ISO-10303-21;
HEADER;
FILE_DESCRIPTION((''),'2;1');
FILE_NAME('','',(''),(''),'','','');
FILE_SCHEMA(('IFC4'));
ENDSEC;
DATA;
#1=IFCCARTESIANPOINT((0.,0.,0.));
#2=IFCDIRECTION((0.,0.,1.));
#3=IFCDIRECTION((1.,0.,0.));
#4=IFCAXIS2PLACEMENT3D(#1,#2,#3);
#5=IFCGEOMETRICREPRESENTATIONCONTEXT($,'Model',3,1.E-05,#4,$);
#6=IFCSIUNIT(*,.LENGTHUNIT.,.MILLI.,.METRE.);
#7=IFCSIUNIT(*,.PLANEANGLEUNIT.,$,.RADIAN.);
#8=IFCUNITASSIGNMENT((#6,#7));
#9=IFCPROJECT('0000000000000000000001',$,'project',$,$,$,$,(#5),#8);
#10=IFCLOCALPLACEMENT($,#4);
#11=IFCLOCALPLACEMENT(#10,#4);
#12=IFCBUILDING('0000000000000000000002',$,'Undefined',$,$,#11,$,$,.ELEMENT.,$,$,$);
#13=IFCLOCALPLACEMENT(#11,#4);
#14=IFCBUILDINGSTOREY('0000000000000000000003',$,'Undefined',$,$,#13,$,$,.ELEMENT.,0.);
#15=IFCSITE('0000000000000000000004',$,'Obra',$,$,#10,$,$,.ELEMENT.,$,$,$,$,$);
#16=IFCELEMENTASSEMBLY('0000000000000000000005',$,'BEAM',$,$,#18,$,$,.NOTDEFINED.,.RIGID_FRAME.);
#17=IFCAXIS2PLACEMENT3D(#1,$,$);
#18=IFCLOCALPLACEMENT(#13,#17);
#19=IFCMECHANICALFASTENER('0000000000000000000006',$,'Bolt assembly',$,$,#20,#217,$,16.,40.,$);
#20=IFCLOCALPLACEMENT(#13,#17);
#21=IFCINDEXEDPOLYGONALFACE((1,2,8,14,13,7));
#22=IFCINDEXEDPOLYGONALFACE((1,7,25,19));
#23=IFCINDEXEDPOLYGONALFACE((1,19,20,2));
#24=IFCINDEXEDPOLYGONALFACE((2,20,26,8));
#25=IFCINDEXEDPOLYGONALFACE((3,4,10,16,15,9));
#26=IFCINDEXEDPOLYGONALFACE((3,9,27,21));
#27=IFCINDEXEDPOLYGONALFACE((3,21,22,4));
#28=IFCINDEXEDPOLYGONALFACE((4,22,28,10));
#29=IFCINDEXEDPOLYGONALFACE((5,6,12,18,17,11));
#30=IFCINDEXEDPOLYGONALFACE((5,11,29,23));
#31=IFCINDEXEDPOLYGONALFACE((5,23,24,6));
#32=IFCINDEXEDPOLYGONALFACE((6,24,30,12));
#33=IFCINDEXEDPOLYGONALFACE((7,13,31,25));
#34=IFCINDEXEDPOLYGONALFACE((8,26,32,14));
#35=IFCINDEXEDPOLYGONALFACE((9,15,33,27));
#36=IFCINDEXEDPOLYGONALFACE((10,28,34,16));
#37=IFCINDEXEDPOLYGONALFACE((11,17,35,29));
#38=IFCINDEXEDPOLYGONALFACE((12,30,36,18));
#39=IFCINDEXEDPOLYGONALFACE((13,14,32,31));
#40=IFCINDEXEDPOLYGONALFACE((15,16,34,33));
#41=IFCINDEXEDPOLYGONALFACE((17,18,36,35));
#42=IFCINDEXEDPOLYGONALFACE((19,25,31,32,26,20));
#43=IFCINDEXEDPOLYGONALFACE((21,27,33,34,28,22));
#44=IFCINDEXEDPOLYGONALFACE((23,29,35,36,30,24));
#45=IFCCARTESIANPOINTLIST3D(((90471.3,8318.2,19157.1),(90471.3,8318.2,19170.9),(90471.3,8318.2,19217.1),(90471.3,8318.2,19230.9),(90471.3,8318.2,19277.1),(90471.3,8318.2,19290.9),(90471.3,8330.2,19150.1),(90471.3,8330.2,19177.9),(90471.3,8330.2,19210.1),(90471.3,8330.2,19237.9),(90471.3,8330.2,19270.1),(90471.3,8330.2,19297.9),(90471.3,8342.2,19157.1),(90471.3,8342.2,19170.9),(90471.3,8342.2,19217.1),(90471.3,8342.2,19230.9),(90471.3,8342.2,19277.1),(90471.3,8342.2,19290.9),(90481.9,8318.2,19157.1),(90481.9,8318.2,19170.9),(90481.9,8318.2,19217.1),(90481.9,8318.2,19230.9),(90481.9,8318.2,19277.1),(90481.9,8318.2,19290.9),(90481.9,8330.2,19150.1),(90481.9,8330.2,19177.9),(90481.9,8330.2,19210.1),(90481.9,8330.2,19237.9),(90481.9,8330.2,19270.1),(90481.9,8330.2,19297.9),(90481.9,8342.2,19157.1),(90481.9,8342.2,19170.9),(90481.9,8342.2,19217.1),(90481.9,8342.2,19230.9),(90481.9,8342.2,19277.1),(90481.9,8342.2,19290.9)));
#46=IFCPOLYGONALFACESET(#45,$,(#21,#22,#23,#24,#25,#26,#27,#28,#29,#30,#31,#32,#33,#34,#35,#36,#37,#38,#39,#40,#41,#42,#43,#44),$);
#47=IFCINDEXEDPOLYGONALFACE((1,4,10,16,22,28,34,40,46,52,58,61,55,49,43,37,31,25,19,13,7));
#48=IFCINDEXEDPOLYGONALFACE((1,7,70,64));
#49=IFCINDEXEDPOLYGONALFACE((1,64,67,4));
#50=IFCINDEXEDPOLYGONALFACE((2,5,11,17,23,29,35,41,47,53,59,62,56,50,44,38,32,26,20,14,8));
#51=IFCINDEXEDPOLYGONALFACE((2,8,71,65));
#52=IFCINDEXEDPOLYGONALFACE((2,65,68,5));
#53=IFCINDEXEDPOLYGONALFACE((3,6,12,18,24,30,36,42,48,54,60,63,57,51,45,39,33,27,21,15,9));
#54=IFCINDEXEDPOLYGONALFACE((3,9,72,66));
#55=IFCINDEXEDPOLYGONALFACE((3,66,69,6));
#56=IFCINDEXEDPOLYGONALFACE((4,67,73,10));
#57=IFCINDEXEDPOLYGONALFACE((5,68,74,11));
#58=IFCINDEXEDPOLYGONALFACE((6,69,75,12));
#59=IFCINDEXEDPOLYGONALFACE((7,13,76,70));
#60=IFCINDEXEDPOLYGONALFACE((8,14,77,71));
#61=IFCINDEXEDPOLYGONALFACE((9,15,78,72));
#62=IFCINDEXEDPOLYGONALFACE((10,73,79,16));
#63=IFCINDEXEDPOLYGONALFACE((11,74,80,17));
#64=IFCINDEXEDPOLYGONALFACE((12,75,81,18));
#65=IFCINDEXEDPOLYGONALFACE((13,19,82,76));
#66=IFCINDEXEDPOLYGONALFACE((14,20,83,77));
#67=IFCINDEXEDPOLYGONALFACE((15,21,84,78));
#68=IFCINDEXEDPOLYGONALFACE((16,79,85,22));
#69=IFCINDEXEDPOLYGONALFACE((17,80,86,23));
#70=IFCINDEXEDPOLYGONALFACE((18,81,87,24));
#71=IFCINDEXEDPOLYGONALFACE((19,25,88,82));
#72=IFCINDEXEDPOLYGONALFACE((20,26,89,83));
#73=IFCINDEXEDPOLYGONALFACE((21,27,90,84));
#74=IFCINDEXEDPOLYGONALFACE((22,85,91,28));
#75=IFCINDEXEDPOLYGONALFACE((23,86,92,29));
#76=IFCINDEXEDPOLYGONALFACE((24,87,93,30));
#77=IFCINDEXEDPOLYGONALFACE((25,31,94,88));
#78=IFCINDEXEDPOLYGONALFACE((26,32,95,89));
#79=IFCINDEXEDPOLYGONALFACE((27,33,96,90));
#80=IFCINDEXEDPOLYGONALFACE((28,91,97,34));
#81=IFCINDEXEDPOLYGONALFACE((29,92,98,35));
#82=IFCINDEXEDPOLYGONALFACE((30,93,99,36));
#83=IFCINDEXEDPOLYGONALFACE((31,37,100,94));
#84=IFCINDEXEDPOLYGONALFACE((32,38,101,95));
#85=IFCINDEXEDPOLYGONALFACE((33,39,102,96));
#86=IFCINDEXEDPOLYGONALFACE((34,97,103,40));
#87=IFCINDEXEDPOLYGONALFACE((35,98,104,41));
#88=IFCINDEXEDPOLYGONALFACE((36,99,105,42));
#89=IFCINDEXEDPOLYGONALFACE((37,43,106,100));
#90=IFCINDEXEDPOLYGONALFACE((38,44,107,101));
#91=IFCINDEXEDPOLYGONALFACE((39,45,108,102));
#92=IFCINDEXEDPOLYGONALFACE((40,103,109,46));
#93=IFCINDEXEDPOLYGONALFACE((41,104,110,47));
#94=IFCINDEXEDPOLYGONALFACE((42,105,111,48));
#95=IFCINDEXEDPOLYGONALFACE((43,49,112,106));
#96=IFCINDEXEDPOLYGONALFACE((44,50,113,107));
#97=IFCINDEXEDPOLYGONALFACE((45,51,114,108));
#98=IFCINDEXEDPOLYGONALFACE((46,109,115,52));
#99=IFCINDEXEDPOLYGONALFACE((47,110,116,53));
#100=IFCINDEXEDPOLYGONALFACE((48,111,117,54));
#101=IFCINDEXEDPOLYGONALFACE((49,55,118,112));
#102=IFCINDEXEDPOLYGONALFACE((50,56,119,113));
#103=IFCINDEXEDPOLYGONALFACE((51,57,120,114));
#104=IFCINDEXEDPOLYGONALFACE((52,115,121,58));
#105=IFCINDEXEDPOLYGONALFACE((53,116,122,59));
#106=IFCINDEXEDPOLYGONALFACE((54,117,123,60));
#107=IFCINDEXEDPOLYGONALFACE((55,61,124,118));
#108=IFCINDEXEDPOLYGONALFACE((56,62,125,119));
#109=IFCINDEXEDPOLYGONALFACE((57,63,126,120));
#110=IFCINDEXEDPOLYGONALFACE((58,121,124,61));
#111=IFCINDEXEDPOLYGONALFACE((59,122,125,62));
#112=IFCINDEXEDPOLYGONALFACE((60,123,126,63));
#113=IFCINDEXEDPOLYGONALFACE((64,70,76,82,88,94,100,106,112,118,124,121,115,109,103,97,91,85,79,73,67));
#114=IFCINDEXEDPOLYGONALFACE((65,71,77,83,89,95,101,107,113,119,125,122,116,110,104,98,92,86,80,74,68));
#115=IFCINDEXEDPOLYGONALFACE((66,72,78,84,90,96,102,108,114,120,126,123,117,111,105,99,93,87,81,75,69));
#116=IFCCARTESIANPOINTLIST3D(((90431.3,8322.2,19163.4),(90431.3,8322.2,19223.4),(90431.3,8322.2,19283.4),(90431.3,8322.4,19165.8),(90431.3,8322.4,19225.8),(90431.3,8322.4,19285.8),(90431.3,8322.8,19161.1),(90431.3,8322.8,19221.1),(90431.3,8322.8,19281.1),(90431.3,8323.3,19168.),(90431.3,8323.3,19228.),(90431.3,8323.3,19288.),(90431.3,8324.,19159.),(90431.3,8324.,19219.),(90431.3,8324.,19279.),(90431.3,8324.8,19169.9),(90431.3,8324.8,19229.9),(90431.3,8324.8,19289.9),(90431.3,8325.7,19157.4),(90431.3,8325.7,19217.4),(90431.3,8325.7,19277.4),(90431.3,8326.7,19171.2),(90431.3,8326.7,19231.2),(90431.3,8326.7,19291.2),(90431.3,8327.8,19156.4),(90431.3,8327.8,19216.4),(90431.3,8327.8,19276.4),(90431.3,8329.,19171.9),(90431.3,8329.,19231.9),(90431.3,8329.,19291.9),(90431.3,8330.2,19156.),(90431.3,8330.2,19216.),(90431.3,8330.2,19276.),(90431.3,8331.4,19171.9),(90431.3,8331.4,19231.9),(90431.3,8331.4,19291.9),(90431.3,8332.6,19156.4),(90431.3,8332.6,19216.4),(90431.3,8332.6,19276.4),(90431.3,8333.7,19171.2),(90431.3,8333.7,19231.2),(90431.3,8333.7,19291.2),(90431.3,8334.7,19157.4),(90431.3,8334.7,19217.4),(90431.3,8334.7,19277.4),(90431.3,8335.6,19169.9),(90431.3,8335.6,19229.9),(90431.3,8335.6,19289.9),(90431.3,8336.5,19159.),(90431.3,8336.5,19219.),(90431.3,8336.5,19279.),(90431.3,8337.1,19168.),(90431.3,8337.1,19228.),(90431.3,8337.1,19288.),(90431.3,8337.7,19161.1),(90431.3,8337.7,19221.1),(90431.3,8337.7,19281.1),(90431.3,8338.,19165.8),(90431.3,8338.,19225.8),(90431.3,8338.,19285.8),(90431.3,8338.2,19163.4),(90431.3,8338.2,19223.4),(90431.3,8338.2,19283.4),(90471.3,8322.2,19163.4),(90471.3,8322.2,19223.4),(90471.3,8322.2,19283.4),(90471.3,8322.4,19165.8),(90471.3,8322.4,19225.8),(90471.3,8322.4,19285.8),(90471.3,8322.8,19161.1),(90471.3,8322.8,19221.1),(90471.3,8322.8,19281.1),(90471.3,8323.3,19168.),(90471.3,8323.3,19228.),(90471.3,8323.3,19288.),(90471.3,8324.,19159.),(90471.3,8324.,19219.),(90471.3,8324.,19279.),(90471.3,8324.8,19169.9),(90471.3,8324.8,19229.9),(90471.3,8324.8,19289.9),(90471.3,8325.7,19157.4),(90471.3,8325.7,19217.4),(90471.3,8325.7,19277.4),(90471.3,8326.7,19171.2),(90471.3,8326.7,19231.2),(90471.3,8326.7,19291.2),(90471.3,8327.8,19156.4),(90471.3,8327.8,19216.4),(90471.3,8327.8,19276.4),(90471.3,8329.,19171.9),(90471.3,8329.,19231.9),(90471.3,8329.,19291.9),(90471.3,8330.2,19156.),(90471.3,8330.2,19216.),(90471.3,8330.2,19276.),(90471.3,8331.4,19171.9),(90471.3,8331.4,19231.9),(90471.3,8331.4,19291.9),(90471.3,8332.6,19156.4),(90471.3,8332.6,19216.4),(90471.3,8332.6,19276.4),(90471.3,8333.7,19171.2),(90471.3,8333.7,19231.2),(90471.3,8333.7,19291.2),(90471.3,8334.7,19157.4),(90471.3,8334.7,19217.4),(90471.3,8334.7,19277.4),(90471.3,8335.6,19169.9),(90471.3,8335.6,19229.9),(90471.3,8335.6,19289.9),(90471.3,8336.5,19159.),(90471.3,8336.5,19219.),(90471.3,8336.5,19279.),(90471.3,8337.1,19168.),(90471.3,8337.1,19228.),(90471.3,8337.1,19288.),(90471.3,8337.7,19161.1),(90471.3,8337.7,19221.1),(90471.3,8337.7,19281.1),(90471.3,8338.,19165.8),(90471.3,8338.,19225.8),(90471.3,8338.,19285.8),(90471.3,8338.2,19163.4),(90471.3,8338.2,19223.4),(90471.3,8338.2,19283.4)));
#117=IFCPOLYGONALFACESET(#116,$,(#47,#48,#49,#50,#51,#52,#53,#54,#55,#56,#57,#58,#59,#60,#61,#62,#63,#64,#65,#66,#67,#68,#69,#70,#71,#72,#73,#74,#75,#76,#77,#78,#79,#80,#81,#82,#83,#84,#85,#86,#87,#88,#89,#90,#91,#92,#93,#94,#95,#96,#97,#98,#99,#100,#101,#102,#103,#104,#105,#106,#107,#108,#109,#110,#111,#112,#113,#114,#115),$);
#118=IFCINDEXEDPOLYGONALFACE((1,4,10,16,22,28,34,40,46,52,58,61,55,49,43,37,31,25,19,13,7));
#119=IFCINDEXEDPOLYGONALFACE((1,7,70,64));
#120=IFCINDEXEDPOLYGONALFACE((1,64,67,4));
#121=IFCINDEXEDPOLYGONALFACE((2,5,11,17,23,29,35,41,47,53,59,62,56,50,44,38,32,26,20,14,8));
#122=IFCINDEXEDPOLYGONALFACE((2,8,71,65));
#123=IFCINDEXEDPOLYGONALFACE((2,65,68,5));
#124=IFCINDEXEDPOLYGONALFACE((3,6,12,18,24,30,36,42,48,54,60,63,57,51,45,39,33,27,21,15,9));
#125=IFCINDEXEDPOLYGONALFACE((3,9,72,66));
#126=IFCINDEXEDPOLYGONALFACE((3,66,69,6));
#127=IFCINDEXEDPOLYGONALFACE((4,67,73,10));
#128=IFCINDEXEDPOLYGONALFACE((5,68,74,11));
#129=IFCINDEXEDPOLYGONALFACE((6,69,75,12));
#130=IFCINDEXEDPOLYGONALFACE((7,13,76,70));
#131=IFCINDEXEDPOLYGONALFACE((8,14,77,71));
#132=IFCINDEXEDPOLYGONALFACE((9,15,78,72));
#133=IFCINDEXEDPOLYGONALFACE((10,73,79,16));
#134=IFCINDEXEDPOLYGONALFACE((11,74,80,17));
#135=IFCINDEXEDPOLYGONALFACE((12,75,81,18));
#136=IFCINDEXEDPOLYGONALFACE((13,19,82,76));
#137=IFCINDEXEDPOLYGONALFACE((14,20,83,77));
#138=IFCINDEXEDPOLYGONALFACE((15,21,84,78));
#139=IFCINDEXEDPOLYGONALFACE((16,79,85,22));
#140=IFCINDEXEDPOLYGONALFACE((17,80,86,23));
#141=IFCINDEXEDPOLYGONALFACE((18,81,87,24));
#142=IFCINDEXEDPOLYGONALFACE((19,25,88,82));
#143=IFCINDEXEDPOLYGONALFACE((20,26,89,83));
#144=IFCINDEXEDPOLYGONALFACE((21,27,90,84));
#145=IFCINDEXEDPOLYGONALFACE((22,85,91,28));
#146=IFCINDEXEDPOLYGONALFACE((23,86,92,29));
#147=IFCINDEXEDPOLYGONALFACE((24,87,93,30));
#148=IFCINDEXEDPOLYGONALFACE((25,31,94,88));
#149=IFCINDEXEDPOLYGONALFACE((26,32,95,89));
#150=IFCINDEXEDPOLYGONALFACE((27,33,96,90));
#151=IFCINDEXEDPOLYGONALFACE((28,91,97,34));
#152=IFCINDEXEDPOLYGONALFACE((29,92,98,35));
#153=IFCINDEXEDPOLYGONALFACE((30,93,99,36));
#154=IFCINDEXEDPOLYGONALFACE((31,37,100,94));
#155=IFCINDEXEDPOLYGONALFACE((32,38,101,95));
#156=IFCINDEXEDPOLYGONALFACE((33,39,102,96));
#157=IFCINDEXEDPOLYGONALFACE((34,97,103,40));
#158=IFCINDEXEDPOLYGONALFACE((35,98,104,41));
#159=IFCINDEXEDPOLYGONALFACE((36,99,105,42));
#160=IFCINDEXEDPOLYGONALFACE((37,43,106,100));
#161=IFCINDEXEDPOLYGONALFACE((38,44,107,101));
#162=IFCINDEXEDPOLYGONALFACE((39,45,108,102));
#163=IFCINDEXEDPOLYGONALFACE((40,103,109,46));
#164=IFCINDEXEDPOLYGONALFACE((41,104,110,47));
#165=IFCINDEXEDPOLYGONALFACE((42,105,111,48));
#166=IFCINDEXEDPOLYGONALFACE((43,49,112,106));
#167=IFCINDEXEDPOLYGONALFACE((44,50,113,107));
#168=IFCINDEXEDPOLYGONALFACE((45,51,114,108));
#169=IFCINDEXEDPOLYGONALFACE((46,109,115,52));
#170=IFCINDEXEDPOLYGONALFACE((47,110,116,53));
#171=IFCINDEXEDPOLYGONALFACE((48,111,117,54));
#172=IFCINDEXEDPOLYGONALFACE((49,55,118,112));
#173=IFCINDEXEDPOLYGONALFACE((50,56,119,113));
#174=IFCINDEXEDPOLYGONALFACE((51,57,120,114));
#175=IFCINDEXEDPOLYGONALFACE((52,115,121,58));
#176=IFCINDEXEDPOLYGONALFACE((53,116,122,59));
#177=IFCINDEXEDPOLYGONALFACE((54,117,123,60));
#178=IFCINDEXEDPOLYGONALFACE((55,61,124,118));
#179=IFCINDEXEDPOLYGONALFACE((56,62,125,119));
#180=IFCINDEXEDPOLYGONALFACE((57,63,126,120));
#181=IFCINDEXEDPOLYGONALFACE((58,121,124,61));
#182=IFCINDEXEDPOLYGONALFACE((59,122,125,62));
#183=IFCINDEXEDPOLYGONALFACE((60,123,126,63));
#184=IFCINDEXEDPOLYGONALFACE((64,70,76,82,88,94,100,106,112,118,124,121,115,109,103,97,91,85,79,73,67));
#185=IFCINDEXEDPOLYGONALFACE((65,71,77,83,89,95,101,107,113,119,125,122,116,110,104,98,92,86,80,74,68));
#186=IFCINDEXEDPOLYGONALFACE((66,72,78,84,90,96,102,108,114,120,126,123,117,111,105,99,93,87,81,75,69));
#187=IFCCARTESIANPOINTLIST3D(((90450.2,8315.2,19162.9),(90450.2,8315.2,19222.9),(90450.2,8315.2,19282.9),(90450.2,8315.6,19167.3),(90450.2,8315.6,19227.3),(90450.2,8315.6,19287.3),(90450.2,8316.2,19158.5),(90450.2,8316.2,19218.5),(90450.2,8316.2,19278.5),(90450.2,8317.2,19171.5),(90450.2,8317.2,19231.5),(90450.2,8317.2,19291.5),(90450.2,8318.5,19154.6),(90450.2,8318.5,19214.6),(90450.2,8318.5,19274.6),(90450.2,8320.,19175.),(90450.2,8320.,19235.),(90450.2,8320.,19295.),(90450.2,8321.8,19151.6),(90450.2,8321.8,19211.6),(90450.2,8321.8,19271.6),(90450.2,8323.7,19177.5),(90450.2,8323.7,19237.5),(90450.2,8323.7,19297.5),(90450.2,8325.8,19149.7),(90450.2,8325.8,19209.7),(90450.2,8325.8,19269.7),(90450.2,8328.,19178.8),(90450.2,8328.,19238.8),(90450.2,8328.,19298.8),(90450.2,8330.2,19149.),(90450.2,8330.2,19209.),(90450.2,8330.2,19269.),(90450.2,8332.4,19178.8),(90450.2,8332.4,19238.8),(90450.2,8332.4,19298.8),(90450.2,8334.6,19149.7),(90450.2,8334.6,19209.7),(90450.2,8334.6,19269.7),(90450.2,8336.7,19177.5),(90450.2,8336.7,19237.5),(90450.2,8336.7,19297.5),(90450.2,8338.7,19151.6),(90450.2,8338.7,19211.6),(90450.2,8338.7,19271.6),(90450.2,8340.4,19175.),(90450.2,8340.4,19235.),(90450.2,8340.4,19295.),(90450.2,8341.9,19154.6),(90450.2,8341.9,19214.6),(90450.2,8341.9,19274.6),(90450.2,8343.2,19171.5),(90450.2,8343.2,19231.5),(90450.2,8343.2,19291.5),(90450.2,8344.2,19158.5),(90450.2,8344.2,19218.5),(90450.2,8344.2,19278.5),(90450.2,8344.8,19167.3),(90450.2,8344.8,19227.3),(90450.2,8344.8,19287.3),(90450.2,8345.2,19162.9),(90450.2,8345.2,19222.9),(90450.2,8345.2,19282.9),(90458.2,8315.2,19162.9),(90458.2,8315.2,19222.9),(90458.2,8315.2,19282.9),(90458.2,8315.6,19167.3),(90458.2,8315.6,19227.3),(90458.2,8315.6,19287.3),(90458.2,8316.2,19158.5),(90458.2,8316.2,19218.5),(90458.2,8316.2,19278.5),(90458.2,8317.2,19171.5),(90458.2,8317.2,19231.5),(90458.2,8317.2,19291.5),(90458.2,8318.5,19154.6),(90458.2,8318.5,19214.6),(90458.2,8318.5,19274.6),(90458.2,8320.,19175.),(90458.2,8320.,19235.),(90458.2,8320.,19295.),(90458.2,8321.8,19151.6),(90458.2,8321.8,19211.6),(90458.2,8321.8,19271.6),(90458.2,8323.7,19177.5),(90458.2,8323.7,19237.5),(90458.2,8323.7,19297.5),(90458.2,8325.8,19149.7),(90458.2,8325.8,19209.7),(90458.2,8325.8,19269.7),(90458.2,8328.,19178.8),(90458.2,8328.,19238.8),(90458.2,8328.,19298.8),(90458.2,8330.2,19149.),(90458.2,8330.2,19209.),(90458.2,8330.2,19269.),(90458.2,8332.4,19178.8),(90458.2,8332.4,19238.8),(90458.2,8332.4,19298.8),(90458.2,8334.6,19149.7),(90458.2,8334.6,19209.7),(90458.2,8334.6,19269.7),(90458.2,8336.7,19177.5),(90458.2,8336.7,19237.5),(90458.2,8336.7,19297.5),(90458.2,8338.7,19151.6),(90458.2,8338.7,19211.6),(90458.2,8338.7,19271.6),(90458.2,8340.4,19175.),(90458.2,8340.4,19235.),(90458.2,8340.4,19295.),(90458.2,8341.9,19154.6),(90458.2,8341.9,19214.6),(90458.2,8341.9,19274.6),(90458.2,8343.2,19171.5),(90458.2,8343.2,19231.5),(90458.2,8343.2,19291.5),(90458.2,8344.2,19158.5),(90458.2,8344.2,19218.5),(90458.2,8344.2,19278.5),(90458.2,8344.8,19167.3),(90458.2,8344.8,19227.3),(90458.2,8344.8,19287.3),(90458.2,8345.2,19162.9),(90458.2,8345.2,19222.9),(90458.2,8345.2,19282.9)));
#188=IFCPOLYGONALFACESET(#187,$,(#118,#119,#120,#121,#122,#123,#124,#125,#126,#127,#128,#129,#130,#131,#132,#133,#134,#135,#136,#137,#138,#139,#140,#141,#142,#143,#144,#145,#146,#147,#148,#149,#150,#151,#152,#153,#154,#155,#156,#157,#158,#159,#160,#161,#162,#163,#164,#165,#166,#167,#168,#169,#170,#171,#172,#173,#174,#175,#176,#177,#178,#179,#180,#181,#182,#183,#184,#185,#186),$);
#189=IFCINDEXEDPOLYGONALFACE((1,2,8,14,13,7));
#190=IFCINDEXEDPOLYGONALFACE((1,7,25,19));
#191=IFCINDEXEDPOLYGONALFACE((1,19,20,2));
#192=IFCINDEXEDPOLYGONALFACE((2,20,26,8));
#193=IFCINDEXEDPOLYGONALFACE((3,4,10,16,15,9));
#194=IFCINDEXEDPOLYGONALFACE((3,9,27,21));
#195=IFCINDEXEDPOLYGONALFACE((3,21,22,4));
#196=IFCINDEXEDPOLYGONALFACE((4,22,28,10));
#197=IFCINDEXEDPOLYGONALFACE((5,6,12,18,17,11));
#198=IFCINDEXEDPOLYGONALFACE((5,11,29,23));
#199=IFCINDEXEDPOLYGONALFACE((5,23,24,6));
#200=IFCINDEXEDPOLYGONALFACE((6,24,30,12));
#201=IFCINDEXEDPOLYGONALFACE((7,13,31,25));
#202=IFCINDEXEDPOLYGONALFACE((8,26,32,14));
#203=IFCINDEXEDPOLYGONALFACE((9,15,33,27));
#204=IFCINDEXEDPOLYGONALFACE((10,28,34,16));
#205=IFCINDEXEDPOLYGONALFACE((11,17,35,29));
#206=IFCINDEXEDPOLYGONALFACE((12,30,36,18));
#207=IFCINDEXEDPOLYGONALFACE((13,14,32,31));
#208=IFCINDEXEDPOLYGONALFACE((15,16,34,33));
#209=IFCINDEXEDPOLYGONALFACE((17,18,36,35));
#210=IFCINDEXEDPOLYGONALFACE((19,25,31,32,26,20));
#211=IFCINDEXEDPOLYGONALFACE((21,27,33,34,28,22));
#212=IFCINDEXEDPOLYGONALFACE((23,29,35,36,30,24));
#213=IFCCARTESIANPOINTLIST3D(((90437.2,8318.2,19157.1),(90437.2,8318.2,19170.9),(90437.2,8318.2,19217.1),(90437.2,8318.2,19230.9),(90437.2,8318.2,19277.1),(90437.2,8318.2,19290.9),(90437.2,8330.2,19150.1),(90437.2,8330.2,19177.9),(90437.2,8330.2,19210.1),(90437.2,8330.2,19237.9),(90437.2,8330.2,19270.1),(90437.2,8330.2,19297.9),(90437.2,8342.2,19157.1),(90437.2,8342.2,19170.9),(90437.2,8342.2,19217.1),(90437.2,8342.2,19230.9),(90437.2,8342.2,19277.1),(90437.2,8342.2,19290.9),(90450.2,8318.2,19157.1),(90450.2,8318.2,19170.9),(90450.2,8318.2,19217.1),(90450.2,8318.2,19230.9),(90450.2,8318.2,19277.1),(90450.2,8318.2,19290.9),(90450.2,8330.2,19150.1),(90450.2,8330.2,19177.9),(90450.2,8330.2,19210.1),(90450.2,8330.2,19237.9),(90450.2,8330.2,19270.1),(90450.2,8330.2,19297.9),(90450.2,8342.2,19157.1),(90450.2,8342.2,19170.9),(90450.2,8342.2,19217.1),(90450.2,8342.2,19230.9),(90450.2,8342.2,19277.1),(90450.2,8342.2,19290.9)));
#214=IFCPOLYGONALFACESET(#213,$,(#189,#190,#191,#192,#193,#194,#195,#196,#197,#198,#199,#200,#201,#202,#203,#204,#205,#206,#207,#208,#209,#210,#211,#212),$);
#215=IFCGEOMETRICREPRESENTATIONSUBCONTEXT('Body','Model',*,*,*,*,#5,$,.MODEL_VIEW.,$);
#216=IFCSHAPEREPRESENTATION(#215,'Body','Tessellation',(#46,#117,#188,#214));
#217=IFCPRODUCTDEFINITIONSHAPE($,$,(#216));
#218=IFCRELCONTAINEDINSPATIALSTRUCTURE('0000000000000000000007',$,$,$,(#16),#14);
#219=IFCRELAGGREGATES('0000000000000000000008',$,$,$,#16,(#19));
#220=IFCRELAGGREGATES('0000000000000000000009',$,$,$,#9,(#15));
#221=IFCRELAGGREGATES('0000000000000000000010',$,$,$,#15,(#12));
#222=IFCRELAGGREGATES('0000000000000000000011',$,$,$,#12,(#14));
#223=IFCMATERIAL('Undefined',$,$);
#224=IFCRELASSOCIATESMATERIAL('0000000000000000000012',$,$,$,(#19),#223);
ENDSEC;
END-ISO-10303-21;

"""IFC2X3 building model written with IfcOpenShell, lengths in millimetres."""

from ifc_helpers import new_model, si_unit, frame, origin_with_axes, origin_2d_with_axis, place, context, subcontext, project, spatial, polyline, circle, outline, extrude, source, transform, mapped, material, element, aggregate, save


model = new_model("IFC2X3")

# Units and contexts
model_context = context("Model", 3, precision=1e-05, world=origin_with_axes())
body_context = subcontext(model_context, "Body", "Model", "MODEL_VIEW")
ifc_project = project(units=[si_unit("LENGTHUNIT", "METRE", prefix="MILLI"), si_unit("PLANEANGLEUNIT", "RADIAN")], contexts=[model_context])

# Site, building, storey
site_placement = place(None, origin_with_axes())
site = spatial("IfcSite", under=ifc_project, at=site_placement, Name="Obra", CompositionType="ELEMENT")
building_placement = place(site_placement, origin_with_axes())
building = spatial("IfcBuilding", under=site, at=building_placement, Name="Undefined", CompositionType="ELEMENT")
storey_placement = place(building_placement, origin_with_axes())
storey = spatial("IfcBuildingStorey", under=building, at=storey_placement, Name="Undefined", CompositionType="ELEMENT", Elevation=0.0)

# Element assembly
assembly_1_placement = place(storey_placement, origin_with_axes())
assembly_1 = element("IfcElementAssembly", 1, at=assembly_1_placement, inside=storey, Name="BEAM", AssemblyPlace="NOTDEFINED", PredefinedType="RIGID_FRAME")

# Shared definitions
ifc_material_1 = material(Name="Undefined")

# Mechanical fastener
shared_shape_1 = source(origin_with_axes(), body_context, "Body", "SweptSolid", [
    extrude(outline(polyline([(13.9, 0.0), (6.9, 12.0), (-6.9, 12.0), (-13.9, 0.0), (-6.9, -12.0), (6.9, -12.0), (13.9, 0.0)])), frame((0.0, -14.1, 0.0), z_axis=(0.0, 1.0, 0.0), x_axis=(1.0, 0.0, 0.0)), (0.0, 0.0, 1.0), 10.6),
    extrude(circle(Radius=8.0, at=origin_2d_with_axis()), frame((0.0, -3.5, 0.0), z_axis=(0.0, 1.0, 0.0), x_axis=(1.0, 0.0, 0.0)), (0.0, 0.0, 1.0), 40.0),
    extrude(circle(Radius=15.0, at=origin_2d_with_axis()), frame((0.0, 9.5, 0.0), z_axis=(0.0, 1.0, 0.0), x_axis=(1.0, 0.0, 0.0)), (0.0, 0.0, 1.0), 8.0),
    extrude(outline(polyline([(13.9, 0.0), (6.9, 12.0), (-6.9, 12.0), (-13.9, 0.0), (-6.9, -12.0), (6.9, -12.0), (13.9, 0.0)])), frame((0.0, 17.5, 0.0), z_axis=(0.0, 1.0, 0.0), x_axis=(1.0, 0.0, 0.0)), (0.0, 0.0, 1.0), 13.0),
])
mechanical_fastener_1_placement = place(assembly_1_placement, frame((90467.7, 8280.2, 19319.0), z_axis=(0.0, 1.0, 0.0), x_axis=(0.0, 0.0, -1.0)))
mechanical_fastener_1 = element("IfcMechanicalFastener", 2, at=mechanical_fastener_1_placement, material=ifc_material_1, Name="Bolt assembly", NominalDiameter=16.0, NominalLength=40.0, context=body_context, shape_type="MappedRepresentation", body=[
    mapped(shared_shape_1, transform((35.0, 0.0, 50.0))),
    mapped(shared_shape_1, transform((95.0, 0.0, 50.0))),
    mapped(shared_shape_1, transform((155.0, 0.0, 50.0))),
])
aggregate(assembly_1, [mechanical_fastener_1])

save(model, "model.ifc")
